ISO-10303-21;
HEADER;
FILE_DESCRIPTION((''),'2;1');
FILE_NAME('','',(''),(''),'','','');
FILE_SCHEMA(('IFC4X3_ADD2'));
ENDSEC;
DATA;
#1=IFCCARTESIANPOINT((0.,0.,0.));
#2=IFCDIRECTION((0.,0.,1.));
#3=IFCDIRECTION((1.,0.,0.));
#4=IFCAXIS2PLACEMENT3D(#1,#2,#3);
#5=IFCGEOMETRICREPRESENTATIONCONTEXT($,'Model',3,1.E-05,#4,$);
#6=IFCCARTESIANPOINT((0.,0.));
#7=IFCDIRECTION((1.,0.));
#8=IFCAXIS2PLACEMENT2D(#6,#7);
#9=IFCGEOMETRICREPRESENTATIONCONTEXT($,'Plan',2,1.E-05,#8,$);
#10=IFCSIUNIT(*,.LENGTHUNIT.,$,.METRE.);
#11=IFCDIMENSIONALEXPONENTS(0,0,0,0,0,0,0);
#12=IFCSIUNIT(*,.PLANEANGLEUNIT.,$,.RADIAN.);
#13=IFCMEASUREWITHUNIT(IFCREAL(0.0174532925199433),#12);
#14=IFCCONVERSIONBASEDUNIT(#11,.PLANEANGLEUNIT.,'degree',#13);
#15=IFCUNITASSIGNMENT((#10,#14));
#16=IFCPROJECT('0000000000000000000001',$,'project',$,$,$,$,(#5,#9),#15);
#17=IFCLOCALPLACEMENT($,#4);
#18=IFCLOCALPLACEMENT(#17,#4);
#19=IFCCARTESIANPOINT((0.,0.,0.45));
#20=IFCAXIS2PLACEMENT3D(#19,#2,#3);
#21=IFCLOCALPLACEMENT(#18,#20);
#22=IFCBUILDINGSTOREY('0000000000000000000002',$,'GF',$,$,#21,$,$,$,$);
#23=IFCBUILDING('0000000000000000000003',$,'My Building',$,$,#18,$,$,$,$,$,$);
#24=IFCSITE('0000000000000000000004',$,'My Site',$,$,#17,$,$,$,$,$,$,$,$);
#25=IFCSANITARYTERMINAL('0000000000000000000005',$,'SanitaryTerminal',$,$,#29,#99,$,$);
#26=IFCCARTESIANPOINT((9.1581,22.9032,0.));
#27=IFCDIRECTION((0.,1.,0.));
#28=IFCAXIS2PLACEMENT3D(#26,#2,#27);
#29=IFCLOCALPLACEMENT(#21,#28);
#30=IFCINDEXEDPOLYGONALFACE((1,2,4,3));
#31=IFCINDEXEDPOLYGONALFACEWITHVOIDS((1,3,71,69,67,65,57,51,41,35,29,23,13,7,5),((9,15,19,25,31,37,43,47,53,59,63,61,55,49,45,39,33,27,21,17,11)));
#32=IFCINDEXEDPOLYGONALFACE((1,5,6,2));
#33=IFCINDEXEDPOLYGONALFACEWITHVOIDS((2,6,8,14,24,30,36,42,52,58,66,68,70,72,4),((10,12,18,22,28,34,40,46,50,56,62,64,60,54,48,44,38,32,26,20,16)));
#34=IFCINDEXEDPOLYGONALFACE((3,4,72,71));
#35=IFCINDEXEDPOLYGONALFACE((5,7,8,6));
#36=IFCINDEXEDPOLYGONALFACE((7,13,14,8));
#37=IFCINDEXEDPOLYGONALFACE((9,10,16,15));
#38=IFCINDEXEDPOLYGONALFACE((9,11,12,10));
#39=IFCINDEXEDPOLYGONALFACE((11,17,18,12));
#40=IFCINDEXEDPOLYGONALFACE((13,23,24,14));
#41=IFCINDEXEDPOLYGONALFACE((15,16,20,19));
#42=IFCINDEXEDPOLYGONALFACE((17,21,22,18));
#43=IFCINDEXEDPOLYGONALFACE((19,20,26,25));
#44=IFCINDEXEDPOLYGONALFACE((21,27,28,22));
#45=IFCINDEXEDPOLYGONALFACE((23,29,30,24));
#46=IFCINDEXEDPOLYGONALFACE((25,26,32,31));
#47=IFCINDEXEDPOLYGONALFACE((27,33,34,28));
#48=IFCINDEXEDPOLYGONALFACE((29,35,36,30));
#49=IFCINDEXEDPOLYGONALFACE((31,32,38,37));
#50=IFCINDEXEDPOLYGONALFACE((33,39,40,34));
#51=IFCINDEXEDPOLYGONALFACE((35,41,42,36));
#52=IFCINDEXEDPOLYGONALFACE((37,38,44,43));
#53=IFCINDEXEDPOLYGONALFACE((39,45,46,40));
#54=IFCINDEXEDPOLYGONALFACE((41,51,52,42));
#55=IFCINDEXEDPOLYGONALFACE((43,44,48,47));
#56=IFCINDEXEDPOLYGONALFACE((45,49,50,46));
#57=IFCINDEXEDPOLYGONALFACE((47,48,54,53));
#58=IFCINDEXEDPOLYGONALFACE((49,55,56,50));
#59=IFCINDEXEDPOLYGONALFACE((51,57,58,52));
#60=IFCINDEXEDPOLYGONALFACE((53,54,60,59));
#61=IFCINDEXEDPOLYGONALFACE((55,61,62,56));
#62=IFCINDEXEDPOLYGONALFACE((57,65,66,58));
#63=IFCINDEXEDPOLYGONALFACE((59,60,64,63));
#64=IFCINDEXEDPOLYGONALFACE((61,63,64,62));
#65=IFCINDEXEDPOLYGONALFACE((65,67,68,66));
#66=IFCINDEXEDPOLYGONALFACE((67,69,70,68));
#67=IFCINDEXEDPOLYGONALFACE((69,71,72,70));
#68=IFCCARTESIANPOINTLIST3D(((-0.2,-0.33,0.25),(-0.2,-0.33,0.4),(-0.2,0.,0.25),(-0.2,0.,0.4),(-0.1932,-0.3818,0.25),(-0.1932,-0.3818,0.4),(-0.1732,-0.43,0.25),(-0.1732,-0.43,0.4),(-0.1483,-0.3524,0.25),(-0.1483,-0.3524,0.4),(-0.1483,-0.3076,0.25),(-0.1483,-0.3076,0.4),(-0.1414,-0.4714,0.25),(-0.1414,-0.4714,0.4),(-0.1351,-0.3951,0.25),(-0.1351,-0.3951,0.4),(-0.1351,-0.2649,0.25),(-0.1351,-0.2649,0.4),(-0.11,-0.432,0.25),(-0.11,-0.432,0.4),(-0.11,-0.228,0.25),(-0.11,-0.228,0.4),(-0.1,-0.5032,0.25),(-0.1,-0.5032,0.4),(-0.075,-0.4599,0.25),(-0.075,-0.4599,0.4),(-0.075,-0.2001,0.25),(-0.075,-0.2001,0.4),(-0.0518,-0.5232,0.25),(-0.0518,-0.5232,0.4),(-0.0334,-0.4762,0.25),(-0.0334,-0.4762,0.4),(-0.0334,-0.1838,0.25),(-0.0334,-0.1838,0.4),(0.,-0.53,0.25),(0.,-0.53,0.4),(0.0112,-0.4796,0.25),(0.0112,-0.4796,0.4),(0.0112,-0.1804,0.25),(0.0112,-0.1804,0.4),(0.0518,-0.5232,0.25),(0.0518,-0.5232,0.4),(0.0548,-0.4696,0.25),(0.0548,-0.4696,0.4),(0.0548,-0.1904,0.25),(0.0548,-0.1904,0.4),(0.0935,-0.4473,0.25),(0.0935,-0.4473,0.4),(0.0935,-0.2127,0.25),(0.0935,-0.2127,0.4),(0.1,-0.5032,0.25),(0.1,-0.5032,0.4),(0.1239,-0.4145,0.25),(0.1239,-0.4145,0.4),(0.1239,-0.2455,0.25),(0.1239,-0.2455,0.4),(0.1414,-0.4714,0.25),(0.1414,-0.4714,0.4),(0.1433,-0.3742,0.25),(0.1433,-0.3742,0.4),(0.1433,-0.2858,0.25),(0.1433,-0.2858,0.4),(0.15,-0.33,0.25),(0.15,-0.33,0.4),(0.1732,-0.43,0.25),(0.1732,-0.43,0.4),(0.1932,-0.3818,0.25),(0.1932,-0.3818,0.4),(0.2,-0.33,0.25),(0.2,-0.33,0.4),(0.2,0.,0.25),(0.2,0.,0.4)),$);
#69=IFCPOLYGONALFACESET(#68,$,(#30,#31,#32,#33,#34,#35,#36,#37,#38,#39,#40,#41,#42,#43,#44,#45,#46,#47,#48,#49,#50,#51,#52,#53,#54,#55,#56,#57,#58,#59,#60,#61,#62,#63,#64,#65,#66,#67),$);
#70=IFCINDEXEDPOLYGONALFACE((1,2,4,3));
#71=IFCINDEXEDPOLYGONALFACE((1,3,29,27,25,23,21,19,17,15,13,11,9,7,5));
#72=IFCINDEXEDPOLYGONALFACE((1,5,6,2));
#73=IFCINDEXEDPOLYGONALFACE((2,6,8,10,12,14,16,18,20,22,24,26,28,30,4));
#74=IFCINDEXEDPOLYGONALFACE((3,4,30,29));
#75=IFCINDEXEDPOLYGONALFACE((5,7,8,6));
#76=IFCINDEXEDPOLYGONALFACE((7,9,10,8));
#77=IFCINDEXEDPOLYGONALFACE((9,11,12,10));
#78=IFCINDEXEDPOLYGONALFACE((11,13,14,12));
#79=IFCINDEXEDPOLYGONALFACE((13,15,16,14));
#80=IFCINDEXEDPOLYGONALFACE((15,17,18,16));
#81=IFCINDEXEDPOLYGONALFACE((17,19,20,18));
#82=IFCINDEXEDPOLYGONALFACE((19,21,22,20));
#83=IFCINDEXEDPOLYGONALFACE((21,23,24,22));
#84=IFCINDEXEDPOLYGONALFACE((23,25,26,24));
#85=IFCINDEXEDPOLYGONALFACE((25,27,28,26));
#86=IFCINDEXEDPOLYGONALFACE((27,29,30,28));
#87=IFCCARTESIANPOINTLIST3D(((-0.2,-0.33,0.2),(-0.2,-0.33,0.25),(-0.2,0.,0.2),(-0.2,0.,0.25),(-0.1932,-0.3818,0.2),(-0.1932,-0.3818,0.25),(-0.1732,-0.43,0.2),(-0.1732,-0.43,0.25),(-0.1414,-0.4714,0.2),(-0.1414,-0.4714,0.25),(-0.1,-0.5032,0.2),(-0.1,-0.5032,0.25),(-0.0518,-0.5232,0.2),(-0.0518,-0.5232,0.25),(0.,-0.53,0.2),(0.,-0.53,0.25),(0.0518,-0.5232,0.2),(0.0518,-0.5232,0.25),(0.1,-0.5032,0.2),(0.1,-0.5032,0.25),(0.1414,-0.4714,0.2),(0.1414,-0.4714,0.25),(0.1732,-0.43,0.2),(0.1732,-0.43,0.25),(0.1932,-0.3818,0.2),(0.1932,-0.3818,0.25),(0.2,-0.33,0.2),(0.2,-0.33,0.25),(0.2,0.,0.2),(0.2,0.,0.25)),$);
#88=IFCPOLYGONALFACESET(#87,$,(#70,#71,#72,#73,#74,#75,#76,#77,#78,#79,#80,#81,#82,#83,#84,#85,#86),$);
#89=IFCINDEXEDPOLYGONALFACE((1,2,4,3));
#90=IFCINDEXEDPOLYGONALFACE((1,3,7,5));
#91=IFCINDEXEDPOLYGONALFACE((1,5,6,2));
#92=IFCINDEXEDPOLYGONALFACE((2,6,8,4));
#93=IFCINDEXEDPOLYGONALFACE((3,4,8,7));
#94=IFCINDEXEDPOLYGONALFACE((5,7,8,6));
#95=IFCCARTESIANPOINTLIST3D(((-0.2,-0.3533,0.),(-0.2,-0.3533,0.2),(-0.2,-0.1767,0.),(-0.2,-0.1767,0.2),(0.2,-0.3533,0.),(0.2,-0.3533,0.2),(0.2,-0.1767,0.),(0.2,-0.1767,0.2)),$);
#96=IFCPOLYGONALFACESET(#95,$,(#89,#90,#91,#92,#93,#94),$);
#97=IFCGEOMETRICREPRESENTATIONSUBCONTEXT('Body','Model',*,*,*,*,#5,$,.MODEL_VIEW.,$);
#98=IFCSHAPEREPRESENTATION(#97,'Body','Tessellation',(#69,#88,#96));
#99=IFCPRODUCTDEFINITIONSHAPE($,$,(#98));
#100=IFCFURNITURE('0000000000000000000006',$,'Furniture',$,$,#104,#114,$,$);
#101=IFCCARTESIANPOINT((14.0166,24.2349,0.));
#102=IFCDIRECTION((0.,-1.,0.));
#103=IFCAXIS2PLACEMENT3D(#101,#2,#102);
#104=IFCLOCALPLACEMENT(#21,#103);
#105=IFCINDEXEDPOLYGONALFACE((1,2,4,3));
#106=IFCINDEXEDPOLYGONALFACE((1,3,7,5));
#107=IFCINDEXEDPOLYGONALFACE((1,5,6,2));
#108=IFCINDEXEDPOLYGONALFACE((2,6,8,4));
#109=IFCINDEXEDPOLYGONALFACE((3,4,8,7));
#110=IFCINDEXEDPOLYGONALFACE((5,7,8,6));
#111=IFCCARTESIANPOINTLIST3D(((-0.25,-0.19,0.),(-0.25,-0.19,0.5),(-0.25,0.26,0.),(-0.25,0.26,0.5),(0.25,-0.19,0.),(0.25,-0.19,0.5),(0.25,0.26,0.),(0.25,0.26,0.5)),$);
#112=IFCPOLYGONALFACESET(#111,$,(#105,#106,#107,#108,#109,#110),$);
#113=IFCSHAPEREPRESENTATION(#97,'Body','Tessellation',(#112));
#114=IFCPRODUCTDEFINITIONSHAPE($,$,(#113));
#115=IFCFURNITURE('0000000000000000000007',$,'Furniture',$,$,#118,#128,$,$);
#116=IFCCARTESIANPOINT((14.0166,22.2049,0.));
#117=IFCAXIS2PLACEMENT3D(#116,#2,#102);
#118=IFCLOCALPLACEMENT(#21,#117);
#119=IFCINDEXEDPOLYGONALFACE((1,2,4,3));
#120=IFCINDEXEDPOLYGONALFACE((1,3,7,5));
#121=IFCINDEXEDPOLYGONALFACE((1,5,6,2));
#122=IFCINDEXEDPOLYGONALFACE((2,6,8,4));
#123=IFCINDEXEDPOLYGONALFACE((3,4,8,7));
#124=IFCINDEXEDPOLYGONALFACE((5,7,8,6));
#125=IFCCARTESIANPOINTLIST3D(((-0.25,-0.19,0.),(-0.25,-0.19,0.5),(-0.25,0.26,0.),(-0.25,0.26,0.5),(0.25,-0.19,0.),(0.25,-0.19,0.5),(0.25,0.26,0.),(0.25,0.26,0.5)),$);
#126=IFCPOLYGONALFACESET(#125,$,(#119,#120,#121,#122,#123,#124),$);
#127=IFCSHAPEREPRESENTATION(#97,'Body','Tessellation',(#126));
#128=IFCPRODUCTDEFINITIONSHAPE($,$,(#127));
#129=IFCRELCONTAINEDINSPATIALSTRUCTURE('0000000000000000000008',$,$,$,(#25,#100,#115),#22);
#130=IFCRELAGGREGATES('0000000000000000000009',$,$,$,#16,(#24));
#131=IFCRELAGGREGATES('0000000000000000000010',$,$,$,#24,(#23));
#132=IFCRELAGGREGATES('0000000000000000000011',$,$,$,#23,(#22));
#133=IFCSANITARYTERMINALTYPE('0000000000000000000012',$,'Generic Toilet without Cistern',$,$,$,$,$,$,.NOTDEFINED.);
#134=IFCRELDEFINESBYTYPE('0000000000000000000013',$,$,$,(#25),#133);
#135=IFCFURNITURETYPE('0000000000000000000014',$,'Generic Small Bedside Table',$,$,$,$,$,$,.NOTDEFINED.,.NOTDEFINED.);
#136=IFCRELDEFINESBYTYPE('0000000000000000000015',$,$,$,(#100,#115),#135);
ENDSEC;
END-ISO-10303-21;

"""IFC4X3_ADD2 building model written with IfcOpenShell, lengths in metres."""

from ifc_helpers import new_model, entity, si_unit, converted_unit, frame, frame_2d, origin_with_axes, origin_2d_with_axis, place, context, subcontext, project, spatial, line, arc, indexed_curve, circle_curve, outline, extrude, shape, source, transform, mapped, type_object, type_shapes, element, save


model = new_model("IFC4X3_ADD2")

# Units and contexts
model_context = context("Model", 3, precision=1e-05, world=origin_with_axes())
plan_context = context("Plan", 2, precision=1e-05, world=origin_2d_with_axis())
body_context_1 = subcontext(model_context, "Body", "Model", "MODEL_VIEW")
body_context_2 = subcontext(plan_context, "Body", "Plan", "PLAN_VIEW")
ifc_project = project(units=[si_unit("LENGTHUNIT", "METRE"), converted_unit("PLANEANGLEUNIT", "degree", entity("IfcReal", 0.0174532925199433), si_unit("PLANEANGLEUNIT", "RADIAN"), dimensions=[0, 0, 0, 0, 0, 0, 0])], contexts=[model_context, plan_context])

# Site, building, storey
site_placement = place(None, origin_with_axes())
site = spatial("IfcSite", under=ifc_project, at=site_placement, Name="My Site")
building_placement = place(site_placement, origin_with_axes())
building = spatial("IfcBuilding", under=site, at=building_placement, Name="My Building")
storey_placement = place(building_placement, frame((0.0, 0.0, 0.45), z_axis=(0.0, 0.0, 1.0), x_axis=(1.0, 0.0, 0.0)))
storey = spatial("IfcBuildingStorey", under=building, at=storey_placement, Name="GF")

# Sanitary terminal
sanitary_terminal_type_1 = type_object("IfcSanitaryTerminalType", Name="Generic Toilet without Cistern", PredefinedType="NOTDEFINED")
shared_shape_1 = source(origin_with_axes(), body_context_1, "Body", "SweptSolid", [
    extrude(outline(indexed_curve([(-0.2, 0.0), (0.2, 0.0), (0.2, -0.33), (0.1414, -0.4714), (0.0, -0.53), (-0.1414, -0.4714), (-0.2, -0.33)], segments=[line(1, 2), line(2, 3), arc(3, 4, 5), arc(5, 6, 7), line(7, 1)]), holes=[circle_curve(frame_2d((0.0, -0.33)), 0.15)]), frame((0.0, 0.0, 0.25), z_axis=(0.0, 0.0, 1.0), x_axis=(1.0, 0.0, 0.0)), (0.0, 0.0, 1.0), 0.15),
    extrude(outline(indexed_curve([(-0.2, 0.0), (0.2, 0.0), (0.2, -0.33), (0.1414, -0.4714), (0.0, -0.53), (-0.1414, -0.4714), (-0.2, -0.33)], segments=[line(1, 2), line(2, 3), arc(3, 4, 5), arc(5, 6, 7), line(7, 1)])), frame((0.0, 0.0, 0.2), z_axis=(0.0, 0.0, 1.0), x_axis=(1.0, 0.0, 0.0)), (0.0, 0.0, 1.0), 0.05),
    extrude(outline(indexed_curve([(-0.2, -0.1767), (0.2, -0.1767), (0.2, -0.3533), (-0.2, -0.3533)], segments=[line(1, 2, 3, 4, 1)])), origin_with_axes(), (0.0, 0.0, 1.0), 0.2),
])
shared_shape_2 = source(origin_with_axes(), body_context_2, "Body", "Annotation2D", [
    entity("IfcGeometricCurveSet", [entity("IfcIndexedPolyCurve", entity("IfcCartesianPointList2D", [[-0.1068, -0.124], [-0.0957, -0.1129], [-0.0804, -0.1088], [0.0804, -0.1088], [0.0957, -0.1129], [0.1068, -0.124], [0.1109, -0.1393], [0.1109, -0.3476], [0.1025, -0.3926], [0.0784, -0.4308], [0.0424, -0.4563], [0.0, -0.4652], [-0.0424, -0.4563], [-0.0784, -0.4308], [-0.1025, -0.3926], [-0.1109, -0.3476], [-0.1109, -0.1393]]), [entity("IfcLineIndex", [1, 2, 3, 4, 5, 6, 7, 8, 9, 10, 11, 12, 13, 14, 15, 16, 17, 1])]), entity("IfcIndexedPolyCurve", entity("IfcCartesianPointList2D", [[-0.1962, -0.2314], [-0.1848, -0.301], [-0.1764, -0.3339], [-0.1663, -0.3651], [-0.1546, -0.3944], [-0.1414, -0.4213], [-0.1269, -0.4458], [-0.1111, -0.4675], [-0.0943, -0.4862], [-0.0765, -0.5018], [-0.0581, -0.514], [-0.039, -0.5229], [-0.0196, -0.5282], [0.0, -0.53], [0.0196, -0.5282], [0.039, -0.5229], [0.0581, -0.514], [0.0765, -0.5018], [0.0943, -0.4862], [0.1111, -0.4675], [0.1269, -0.4458], [0.1414, -0.4213], [0.1546, -0.3944], [0.1663, -0.3651], [0.1764, -0.3339], [0.1848, -0.301], [0.1962, -0.2314], [0.2, -0.159], [0.1872, 0.0], [-0.1872, 0.0], [-0.2, -0.159]]), [entity("IfcLineIndex", [1, 2, 3, 4, 5, 6, 7, 8, 9, 10, 11, 12, 13, 14, 15, 16, 17, 18, 19, 20, 21, 22, 23, 24, 25, 26, 27, 28, 29, 30, 31, 1])])]),
])
type_shapes(sanitary_terminal_type_1, [shared_shape_1, shared_shape_2])
for number, where, z_axis, x_axis, name in (
    (1, (9.1581, 22.9032, 0.0), (0.0, 0.0, 1.0), (0.0, 1.0, 0.0), "SanitaryTerminal"),
):
    element("IfcSanitaryTerminal", number, at=place(storey_placement, frame(where, z_axis=z_axis, x_axis=x_axis)), inside=storey, type_object=sanitary_terminal_type_1, Name=name, shapes=[
        shape(body_context_1, "Body", "MappedRepresentation", [mapped(shared_shape_1, transform((0.0, 0.0, 0.0), x_axis=(1.0, 0.0, 0.0), y_axis=(0.0, 1.0, 0.0), z_axis=(0.0, 0.0, 1.0), scale=1.0))]),
        shape(body_context_2, "Body", "MappedRepresentation", [mapped(shared_shape_2, transform((0.0, 0.0, 0.0), x_axis=(1.0, 0.0, 0.0), y_axis=(0.0, 1.0, 0.0), z_axis=(0.0, 0.0, 1.0), scale=1.0))]),
    ])

# Furniture
furniture_type_1 = type_object("IfcFurnitureType", Name="Generic Small Bedside Table", AssemblyPlace="NOTDEFINED", PredefinedType="NOTDEFINED")
shared_shape_3 = source(origin_with_axes(), body_context_1, "Body", "SweptSolid", [
    extrude(outline(indexed_curve([(0.5, 0.45), (0.5, 0.0), (0.0, 0.0), (0.0, 0.45)], segments=[line(4, 1), line(1, 2), line(2, 3), line(3, 4)], self_intersect=False)), frame((-0.25, -0.19, 0.0), z_axis=(0.0, 0.0, 1.0), x_axis=(1.0, 0.0, 0.0)), (0.0, 0.0, 1.0), 0.5),
])
shared_shape_4 = source(origin_with_axes(), body_context_2, "Body", "Annotation2D", [
    entity("IfcGeometricCurveSet", [entity("IfcIndexedPolyCurve", entity("IfcCartesianPointList2D", [[-0.25, -0.19], [0.25, -0.19], [0.25, 0.26], [-0.25, 0.26]]), [entity("IfcLineIndex", [1, 2]), entity("IfcLineIndex", [2, 3]), entity("IfcLineIndex", [3, 4]), entity("IfcLineIndex", [4, 1])])]),
])
type_shapes(furniture_type_1, [shared_shape_3, shared_shape_4])
for number, where, z_axis, x_axis, name in (
    (2, (14.0166, 24.2349, 0.0), (0.0, 0.0, 1.0), (0.0, -1.0, 0.0), "Furniture"),
    (3, (14.0166, 22.2049, 0.0), (0.0, 0.0, 1.0), (0.0, -1.0, 0.0), "Furniture"),
):
    element("IfcFurniture", number, at=place(storey_placement, frame(where, z_axis=z_axis, x_axis=x_axis)), inside=storey, type_object=furniture_type_1, Name=name, shapes=[
        shape(body_context_1, "Body", "MappedRepresentation", [mapped(shared_shape_3, transform((0.0, 0.0, 0.0), x_axis=(1.0, 0.0, 0.0), y_axis=(0.0, 1.0, 0.0), z_axis=(0.0, 0.0, 1.0), scale=1.0))]),
        shape(body_context_2, "Body", "MappedRepresentation", [mapped(shared_shape_4, transform((0.0, 0.0, 0.0), x_axis=(1.0, 0.0, 0.0), y_axis=(0.0, 1.0, 0.0), z_axis=(0.0, 0.0, 1.0), scale=1.0))]),
    ])

save(model, "model.ifc")
